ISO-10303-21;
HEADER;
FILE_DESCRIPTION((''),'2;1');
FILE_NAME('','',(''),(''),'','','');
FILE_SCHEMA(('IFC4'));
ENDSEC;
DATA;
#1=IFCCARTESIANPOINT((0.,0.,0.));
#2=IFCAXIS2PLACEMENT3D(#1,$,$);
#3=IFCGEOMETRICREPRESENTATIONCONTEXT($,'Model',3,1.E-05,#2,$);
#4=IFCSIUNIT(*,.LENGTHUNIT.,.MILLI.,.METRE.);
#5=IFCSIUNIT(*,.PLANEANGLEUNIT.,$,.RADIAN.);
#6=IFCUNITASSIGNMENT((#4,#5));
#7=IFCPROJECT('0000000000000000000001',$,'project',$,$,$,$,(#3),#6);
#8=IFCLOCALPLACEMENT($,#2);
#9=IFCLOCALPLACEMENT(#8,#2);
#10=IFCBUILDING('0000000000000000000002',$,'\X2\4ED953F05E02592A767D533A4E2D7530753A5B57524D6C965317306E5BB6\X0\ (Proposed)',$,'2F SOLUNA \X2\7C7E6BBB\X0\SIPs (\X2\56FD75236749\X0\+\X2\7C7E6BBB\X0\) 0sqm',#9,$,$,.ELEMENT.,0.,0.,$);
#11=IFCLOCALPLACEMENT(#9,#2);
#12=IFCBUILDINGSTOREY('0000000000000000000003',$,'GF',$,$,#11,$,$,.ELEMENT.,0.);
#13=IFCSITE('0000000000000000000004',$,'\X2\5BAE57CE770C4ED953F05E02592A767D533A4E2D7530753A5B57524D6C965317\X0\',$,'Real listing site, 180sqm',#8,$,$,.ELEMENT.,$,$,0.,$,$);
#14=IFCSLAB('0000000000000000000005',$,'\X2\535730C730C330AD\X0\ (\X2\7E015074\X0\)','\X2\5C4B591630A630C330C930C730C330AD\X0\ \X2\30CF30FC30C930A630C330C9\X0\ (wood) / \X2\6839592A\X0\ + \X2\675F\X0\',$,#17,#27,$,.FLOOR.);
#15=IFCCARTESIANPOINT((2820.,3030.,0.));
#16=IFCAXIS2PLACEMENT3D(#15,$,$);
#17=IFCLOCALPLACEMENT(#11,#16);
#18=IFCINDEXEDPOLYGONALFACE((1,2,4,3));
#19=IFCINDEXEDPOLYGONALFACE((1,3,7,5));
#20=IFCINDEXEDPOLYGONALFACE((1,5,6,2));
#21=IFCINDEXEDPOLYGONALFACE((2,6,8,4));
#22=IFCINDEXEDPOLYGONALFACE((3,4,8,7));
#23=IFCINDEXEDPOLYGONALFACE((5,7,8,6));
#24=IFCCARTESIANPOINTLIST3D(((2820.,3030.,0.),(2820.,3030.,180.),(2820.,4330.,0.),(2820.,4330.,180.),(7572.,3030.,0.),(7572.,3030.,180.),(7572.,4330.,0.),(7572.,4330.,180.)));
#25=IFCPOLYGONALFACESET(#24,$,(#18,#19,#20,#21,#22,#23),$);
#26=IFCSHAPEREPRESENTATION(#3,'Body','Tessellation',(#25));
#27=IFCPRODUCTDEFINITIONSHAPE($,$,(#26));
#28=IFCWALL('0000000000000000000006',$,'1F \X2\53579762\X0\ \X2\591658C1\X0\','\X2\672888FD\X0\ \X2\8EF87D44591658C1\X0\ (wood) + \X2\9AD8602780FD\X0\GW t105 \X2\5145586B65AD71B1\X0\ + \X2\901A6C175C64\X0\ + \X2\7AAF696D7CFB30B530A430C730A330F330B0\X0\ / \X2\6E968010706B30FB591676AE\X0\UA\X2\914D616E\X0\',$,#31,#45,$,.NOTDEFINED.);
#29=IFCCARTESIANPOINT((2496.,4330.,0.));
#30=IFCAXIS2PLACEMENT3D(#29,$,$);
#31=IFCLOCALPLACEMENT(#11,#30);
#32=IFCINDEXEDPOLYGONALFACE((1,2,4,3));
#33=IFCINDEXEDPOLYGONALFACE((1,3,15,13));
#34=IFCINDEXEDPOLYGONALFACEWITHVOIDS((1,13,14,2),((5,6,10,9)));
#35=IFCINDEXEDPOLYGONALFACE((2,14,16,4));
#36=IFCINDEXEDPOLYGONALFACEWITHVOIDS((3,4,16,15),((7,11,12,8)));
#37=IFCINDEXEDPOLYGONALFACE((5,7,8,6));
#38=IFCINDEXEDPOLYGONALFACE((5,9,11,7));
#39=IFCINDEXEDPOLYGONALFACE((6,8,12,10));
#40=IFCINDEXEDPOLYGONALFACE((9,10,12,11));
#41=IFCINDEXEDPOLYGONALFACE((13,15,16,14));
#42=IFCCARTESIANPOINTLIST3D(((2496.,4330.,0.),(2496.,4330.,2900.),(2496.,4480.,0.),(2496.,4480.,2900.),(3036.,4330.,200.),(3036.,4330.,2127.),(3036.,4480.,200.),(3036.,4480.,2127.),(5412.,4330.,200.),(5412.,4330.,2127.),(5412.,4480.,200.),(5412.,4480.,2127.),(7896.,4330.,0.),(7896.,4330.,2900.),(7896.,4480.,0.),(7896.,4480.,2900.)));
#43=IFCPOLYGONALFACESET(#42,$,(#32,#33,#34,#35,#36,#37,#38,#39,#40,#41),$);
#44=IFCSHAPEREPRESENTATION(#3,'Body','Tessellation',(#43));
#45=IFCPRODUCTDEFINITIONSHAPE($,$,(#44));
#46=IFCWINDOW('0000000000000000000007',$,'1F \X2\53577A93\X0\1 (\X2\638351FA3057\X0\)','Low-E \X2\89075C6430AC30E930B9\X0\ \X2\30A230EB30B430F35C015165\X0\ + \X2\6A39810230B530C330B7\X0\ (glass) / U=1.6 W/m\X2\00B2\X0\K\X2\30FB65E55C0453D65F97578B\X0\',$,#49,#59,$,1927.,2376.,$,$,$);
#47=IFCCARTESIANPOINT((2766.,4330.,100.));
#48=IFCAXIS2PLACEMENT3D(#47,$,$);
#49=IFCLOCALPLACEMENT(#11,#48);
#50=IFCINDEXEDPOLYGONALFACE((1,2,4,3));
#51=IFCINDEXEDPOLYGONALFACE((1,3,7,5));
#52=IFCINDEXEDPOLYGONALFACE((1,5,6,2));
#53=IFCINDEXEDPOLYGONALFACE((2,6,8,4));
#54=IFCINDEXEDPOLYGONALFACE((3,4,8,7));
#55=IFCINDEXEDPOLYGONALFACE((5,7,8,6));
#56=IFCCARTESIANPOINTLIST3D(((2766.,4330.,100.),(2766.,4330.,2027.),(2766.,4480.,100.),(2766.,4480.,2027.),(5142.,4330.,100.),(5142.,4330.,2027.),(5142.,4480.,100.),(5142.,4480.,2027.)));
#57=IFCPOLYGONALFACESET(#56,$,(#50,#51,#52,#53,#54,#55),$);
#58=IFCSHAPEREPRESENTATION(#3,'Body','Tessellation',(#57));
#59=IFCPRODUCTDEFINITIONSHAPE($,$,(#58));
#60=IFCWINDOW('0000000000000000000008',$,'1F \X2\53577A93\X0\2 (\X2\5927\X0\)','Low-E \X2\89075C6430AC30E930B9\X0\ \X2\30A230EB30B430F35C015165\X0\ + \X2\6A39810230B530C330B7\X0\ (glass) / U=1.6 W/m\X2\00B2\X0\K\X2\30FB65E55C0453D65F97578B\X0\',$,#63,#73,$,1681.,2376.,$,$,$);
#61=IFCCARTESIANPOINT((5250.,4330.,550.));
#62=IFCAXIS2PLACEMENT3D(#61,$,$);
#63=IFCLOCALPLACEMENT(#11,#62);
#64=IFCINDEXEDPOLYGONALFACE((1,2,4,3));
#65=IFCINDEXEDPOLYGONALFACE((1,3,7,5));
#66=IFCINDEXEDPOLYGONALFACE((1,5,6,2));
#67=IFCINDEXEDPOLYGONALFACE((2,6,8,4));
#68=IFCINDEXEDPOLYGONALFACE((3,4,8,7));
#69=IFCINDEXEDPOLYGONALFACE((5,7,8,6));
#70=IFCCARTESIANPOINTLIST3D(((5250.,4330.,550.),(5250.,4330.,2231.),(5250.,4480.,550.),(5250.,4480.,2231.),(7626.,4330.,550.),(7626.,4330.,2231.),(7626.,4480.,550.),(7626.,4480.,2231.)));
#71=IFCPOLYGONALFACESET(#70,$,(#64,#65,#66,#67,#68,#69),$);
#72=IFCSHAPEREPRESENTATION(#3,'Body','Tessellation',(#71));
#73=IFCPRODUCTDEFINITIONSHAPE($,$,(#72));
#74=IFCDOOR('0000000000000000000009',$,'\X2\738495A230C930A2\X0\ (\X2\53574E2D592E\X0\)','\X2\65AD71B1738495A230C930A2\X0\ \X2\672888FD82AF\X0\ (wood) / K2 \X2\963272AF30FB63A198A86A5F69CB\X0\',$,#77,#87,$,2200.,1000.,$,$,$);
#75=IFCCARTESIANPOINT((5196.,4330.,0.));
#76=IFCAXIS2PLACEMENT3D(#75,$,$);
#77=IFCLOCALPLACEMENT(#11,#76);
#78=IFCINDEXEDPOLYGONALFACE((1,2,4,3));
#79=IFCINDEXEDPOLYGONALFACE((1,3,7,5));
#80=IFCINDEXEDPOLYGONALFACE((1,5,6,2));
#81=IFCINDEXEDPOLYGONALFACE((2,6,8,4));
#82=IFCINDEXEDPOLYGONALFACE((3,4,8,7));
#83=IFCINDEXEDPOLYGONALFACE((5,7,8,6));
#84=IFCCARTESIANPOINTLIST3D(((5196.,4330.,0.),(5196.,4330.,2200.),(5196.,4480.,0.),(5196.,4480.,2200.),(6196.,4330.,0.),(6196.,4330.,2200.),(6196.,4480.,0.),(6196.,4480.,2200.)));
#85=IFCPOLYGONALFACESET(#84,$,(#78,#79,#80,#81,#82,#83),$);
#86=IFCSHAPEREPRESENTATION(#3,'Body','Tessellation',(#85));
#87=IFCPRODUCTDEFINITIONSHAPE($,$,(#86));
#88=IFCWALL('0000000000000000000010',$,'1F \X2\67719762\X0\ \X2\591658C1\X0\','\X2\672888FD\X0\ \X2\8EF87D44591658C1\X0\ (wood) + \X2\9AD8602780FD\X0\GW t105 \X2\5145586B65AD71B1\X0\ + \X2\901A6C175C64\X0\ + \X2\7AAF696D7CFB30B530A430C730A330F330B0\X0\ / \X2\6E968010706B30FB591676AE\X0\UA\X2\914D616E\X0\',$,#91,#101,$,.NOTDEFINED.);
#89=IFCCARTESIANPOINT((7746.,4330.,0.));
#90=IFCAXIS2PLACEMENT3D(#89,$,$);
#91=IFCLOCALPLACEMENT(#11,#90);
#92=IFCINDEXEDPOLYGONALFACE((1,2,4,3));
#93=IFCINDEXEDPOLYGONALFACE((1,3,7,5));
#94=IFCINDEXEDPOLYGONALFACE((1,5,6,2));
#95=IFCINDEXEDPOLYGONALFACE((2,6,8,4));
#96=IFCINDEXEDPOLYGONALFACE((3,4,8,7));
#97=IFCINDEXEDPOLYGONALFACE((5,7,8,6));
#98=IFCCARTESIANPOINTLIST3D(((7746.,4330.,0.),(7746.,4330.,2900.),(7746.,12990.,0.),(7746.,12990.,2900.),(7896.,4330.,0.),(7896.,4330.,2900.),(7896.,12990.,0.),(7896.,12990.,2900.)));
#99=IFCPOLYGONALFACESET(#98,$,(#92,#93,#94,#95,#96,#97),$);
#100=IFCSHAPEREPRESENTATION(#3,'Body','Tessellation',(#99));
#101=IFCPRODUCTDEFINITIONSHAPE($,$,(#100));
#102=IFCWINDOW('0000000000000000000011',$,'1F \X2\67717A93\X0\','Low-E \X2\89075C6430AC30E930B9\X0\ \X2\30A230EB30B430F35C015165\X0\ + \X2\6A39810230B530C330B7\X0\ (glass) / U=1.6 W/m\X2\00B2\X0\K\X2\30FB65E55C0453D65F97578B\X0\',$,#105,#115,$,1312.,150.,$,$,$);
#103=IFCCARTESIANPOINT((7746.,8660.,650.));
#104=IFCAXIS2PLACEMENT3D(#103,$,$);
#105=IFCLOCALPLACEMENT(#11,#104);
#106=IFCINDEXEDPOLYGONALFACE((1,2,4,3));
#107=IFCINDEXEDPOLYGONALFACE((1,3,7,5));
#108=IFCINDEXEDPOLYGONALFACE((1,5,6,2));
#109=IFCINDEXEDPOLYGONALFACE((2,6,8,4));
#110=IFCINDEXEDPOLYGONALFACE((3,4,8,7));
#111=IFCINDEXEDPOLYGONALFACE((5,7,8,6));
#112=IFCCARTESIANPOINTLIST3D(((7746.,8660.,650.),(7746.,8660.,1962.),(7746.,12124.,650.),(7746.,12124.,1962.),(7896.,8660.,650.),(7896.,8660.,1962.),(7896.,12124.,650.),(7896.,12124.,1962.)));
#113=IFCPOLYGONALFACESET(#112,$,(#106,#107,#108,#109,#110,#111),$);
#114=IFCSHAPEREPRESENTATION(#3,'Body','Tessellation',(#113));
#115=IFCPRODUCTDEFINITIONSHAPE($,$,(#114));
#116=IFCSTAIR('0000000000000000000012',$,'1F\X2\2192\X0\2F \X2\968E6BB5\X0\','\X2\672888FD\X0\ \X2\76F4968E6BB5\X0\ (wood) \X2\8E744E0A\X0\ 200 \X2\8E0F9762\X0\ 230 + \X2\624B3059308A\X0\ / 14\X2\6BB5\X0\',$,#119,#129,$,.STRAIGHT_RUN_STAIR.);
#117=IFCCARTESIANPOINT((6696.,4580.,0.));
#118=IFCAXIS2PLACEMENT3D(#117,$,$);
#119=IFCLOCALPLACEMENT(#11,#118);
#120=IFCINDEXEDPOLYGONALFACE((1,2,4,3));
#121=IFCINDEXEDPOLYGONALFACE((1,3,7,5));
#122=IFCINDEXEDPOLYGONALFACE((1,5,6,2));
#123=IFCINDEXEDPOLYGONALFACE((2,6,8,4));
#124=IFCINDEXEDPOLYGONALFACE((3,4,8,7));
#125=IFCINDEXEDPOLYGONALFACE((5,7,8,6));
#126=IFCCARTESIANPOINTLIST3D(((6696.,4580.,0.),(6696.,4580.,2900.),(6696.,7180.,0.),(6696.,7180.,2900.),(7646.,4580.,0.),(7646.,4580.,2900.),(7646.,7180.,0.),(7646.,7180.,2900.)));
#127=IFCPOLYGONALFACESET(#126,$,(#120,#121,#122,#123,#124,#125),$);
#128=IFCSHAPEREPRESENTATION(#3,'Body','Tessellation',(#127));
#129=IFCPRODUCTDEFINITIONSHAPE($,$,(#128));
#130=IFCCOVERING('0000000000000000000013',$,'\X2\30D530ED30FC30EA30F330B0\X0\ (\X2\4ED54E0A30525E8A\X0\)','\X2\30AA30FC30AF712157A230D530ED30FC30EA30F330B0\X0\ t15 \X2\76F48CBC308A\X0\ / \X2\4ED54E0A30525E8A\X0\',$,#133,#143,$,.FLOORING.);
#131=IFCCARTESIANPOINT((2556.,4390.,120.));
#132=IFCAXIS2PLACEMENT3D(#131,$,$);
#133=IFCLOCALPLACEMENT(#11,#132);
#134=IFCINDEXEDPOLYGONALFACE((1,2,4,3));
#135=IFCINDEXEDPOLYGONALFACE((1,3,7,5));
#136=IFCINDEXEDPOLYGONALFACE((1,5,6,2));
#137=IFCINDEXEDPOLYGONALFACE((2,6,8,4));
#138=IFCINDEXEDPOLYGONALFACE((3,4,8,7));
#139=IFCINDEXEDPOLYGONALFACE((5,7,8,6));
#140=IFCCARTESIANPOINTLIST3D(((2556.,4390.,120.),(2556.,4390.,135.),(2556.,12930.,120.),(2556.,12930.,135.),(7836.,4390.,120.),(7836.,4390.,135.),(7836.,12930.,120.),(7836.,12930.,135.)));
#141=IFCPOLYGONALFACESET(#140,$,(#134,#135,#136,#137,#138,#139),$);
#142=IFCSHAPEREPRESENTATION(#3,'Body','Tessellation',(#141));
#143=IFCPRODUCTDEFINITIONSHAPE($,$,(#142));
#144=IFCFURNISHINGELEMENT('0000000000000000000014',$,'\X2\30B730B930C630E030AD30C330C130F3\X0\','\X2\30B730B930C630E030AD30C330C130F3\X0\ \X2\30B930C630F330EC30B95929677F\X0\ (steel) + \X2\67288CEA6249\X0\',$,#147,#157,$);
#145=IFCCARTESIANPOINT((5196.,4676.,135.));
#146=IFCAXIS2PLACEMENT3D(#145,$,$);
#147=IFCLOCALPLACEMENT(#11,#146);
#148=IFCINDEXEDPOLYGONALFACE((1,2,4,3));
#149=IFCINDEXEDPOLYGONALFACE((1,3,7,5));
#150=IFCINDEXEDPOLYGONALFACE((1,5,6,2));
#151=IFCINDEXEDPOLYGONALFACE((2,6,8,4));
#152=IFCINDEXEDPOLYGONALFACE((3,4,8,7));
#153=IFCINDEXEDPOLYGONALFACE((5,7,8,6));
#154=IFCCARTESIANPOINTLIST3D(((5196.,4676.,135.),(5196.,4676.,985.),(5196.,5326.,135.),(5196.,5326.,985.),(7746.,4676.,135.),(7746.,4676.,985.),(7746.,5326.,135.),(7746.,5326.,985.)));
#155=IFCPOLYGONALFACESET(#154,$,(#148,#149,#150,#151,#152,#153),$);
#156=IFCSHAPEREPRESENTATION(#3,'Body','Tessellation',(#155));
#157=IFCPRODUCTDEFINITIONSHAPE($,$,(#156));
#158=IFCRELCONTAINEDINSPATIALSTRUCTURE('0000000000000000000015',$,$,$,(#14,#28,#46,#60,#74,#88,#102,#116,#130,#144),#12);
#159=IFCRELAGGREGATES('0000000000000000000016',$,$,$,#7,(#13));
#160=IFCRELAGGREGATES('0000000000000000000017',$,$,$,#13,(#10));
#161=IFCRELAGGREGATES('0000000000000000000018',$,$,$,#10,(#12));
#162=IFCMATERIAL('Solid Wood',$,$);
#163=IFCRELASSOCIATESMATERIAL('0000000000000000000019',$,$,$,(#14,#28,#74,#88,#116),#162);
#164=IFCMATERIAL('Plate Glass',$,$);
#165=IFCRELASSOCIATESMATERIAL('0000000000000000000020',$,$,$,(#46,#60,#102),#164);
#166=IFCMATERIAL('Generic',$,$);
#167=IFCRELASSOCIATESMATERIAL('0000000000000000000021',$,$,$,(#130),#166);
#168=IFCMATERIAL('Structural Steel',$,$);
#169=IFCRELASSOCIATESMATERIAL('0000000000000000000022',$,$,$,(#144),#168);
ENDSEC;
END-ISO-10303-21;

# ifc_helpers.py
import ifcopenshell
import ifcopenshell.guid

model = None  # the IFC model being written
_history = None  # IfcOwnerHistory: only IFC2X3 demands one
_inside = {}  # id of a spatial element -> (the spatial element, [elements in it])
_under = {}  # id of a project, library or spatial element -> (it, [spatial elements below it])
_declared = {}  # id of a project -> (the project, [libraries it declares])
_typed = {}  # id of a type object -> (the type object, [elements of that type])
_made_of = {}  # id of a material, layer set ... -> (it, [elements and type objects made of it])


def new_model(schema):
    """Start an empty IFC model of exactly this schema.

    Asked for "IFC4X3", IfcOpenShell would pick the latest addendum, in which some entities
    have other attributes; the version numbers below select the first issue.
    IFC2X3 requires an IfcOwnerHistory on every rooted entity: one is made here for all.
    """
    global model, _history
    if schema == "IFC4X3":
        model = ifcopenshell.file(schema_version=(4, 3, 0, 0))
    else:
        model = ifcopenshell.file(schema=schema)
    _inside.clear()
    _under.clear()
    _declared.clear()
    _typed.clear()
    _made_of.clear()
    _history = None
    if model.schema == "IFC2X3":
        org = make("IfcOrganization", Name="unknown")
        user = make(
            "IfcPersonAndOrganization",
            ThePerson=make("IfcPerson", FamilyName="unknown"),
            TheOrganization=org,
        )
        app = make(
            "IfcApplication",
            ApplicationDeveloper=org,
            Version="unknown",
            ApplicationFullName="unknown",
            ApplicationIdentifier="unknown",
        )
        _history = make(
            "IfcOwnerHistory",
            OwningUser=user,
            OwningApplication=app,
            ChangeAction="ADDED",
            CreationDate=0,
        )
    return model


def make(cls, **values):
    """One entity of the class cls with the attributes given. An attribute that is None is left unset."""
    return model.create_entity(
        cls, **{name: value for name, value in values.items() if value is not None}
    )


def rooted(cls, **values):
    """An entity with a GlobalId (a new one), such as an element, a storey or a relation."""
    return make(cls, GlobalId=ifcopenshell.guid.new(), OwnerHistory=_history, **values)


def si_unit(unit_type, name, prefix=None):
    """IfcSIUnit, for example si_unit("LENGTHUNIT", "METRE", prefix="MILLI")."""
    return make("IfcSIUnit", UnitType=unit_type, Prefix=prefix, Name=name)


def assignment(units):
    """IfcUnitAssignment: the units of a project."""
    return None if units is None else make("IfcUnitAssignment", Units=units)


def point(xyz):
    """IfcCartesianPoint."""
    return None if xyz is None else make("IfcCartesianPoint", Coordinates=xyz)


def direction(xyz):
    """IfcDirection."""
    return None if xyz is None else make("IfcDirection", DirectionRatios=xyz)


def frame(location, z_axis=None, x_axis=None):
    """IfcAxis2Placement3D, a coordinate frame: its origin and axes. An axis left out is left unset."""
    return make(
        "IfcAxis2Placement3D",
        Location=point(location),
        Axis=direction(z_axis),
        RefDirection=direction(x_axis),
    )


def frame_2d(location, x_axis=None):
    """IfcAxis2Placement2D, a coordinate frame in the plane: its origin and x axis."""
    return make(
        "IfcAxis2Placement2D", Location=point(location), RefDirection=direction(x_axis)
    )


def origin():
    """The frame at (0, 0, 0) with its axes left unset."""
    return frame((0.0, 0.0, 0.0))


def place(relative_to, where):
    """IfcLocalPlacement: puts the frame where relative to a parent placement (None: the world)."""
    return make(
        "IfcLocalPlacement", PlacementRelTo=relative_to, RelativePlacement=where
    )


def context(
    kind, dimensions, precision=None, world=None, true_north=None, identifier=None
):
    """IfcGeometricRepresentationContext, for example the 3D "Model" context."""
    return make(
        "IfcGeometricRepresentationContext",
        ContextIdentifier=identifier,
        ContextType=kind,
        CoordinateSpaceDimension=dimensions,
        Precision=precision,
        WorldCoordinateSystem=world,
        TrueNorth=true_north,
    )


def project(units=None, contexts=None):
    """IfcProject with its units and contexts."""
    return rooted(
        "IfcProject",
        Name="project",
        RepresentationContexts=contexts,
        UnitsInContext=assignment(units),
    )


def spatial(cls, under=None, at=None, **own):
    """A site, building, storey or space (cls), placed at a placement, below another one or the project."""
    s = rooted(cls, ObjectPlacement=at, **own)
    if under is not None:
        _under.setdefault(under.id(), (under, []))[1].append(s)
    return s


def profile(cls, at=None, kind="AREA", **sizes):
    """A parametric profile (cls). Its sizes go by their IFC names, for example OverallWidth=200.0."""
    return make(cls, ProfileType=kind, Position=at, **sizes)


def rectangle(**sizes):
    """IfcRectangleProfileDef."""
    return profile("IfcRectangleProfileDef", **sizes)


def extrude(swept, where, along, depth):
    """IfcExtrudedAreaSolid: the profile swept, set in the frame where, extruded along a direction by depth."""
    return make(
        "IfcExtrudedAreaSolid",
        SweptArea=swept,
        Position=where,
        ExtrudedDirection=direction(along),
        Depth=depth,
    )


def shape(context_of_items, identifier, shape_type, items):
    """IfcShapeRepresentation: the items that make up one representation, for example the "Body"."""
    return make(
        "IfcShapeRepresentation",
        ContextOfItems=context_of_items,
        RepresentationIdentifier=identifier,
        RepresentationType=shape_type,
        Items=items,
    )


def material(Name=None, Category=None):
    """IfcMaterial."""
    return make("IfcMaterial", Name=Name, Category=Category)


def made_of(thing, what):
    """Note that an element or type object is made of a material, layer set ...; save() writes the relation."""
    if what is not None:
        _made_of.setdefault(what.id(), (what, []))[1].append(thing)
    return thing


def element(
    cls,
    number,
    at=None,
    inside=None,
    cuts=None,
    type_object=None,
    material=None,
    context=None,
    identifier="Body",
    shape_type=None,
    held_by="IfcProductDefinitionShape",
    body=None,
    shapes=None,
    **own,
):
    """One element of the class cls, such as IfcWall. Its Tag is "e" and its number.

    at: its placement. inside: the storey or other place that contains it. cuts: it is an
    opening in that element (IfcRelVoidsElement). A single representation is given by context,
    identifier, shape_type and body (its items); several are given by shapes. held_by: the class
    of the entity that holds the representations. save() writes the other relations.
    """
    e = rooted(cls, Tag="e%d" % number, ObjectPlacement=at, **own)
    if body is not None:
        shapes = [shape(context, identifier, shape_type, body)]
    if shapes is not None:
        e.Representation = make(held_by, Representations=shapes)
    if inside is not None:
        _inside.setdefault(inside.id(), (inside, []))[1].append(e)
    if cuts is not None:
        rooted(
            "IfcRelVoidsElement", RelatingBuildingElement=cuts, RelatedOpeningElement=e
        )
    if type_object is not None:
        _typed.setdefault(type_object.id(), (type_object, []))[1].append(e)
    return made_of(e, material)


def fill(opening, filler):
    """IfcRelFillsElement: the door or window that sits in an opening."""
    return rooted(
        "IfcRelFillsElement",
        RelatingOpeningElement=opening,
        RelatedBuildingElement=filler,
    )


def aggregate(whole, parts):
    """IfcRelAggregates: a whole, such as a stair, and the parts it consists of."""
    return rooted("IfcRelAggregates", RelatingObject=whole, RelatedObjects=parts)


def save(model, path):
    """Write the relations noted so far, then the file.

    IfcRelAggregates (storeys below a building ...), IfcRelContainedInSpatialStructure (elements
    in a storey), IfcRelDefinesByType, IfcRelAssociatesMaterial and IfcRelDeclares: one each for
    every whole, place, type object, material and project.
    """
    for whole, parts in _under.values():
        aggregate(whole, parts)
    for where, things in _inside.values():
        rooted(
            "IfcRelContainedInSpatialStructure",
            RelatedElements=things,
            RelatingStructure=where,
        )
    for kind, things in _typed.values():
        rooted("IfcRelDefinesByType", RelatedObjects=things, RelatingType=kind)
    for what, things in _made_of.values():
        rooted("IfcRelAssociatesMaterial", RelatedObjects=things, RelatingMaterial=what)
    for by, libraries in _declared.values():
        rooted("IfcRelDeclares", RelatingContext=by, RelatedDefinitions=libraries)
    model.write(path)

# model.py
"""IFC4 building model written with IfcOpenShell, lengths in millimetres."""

from ifc_helpers import new_model, si_unit, frame, frame_2d, origin, place, context, project, spatial, rectangle, extrude, material, element, fill, save


model = new_model("IFC4")

# Units and contexts
model_context = context("Model", 3, precision=1e-05, world=origin())
ifc_project = project(units=[si_unit("LENGTHUNIT", "METRE", prefix="MILLI"), si_unit("PLANEANGLEUNIT", "RADIAN")], contexts=[model_context])

# Site, building, storey
site_placement = place(None, origin())
site = spatial("IfcSite", under=ifc_project, at=site_placement, Name="宮城県仙台市太白区中田町字前沖北", ObjectType="Real listing site, 180sqm", CompositionType="ELEMENT", RefElevation=0.0)
building_placement = place(site_placement, origin())
building = spatial("IfcBuilding", under=site, at=building_placement, Name="仙台市太白区中田町字前沖北の家 (Proposed)", ObjectType="2F SOLUNA 籾殻SIPs (国産杉+籾殻) 0sqm", CompositionType="ELEMENT", ElevationOfRefHeight=0.0, ElevationOfTerrain=0.0)
storey_placement = place(building_placement, origin())
storey = spatial("IfcBuildingStorey", under=building, at=storey_placement, Name="GF", CompositionType="ELEMENT", Elevation=0.0)

# Slab
ifc_material_1 = material(Name="Solid Wood")
slab_1_placement = place(storey_placement, frame((2820.0, 3030.0, 0.0)))
element("IfcSlab", 1, at=slab_1_placement, inside=storey, material=ifc_material_1, Name="南デッキ (縁側)", Description="屋外ウッドデッキ ハードウッド (wood) / 根太 + 束", PredefinedType="FLOOR", context=model_context, shape_type="SweptSolid", body=[
    extrude(rectangle(XDim=4752.0, YDim=1300.0, at=frame_2d((2376.0, 650.0))), frame((2820.0, 3030.0, 0.0)), (0.0, 0.0, 1.0), 180.0),
])

# Wall, openings, windows, door
wall_1_placement = place(storey_placement, frame((2496.0, 4330.0, 0.0)))
wall_1 = element("IfcWall", 2, at=wall_1_placement, inside=storey, material=ifc_material_1, Name="1F 南面 外壁", Description="木製 軸組外壁 (wood) + 高性能GW t105 充填断熱 + 通気層 + 窯業系サイディング / 準耐火・外皮UA配慮", PredefinedType="NOTDEFINED", context=model_context, shape_type="SweptSolid", body=[
    extrude(rectangle(XDim=5400.0, YDim=150.0, at=frame_2d((2700.0, 75.0))), frame((2496.0, 4330.0, 0.0)), (0.0, 0.0, 1.0), 2900.0),
])
opening_1_placement = place(storey_placement, frame((2766.0, 4330.0, 100.0)))
opening_1 = element("IfcOpeningElement", 3, at=opening_1_placement, cuts=wall_1, PredefinedType="NOTDEFINED", context=model_context, shape_type="SweptSolid", body=[
    extrude(rectangle(XDim=2376.0, YDim=150.0, at=frame_2d((1188.0, 75.0))), frame((2766.0, 4330.0, 100.0)), (0.0, 0.0, 1.0), 1927.0),
])
opening_2_placement = place(storey_placement, frame((5250.0, 4330.0, 550.0)))
opening_2 = element("IfcOpeningElement", 4, at=opening_2_placement, cuts=wall_1, PredefinedType="NOTDEFINED", context=model_context, shape_type="SweptSolid", body=[
    extrude(rectangle(XDim=2376.0, YDim=150.0, at=frame_2d((1188.0, 75.0))), frame((5250.0, 4330.0, 550.0)), (0.0, 0.0, 1.0), 1681.0),
])
opening_3_placement = place(storey_placement, frame((5196.0, 4330.0, 0.0)))
opening_3 = element("IfcOpeningElement", 5, at=opening_3_placement, cuts=wall_1, PredefinedType="NOTDEFINED", context=model_context, shape_type="SweptSolid", body=[
    extrude(rectangle(XDim=1000.0, YDim=150.0, at=frame_2d((500.0, 75.0))), frame((5196.0, 4330.0, 0.0)), (0.0, 0.0, 1.0), 2200.0),
])
ifc_material_2 = material(Name="Plate Glass")
window_1_placement = place(storey_placement, frame((2766.0, 4330.0, 100.0)))
window_1 = element("IfcWindow", 6, at=window_1_placement, inside=storey, material=ifc_material_2, Name="1F 南窓1 (掃出し)", Description="Low-E 複層ガラス アルゴン封入 + 樹脂サッシ (glass) / U=1.6 W/m²K・日射取得型", OverallHeight=1927.0, OverallWidth=2376.0, context=model_context, shape_type="SweptSolid", body=[
    extrude(rectangle(XDim=2376.0, YDim=150.0, at=frame_2d((1188.0, 75.0))), frame((2766.0, 4330.0, 100.0)), (0.0, 0.0, 1.0), 1927.0),
])
fill(opening_1, window_1)
window_2_placement = place(storey_placement, frame((5250.0, 4330.0, 550.0)))
window_2 = element("IfcWindow", 7, at=window_2_placement, inside=storey, material=ifc_material_2, Name="1F 南窓2 (大)", Description="Low-E 複層ガラス アルゴン封入 + 樹脂サッシ (glass) / U=1.6 W/m²K・日射取得型", OverallHeight=1681.0, OverallWidth=2376.0, context=model_context, shape_type="SweptSolid", body=[
    extrude(rectangle(XDim=2376.0, YDim=150.0, at=frame_2d((1188.0, 75.0))), frame((5250.0, 4330.0, 550.0)), (0.0, 0.0, 1.0), 1681.0),
])
fill(opening_2, window_2)
door_placement = place(storey_placement, frame((5196.0, 4330.0, 0.0)))
door = element("IfcDoor", 8, at=door_placement, inside=storey, material=ifc_material_1, Name="玄関ドア (南中央)", Description="断熱玄関ドア 木製芯 (wood) / K2 防犯・採風機構", OverallHeight=2200.0, OverallWidth=1000.0, context=model_context, shape_type="SweptSolid", body=[
    extrude(rectangle(XDim=1000.0, YDim=150.0, at=frame_2d((500.0, 75.0))), frame((5196.0, 4330.0, 0.0)), (0.0, 0.0, 1.0), 2200.0),
])
fill(opening_3, door)

# Wall, opening, window
wall_2_placement = place(storey_placement, frame((7746.0, 4330.0, 0.0)))
wall_2 = element("IfcWall", 9, at=wall_2_placement, inside=storey, material=ifc_material_1, Name="1F 東面 外壁", Description="木製 軸組外壁 (wood) + 高性能GW t105 充填断熱 + 通気層 + 窯業系サイディング / 準耐火・外皮UA配慮", PredefinedType="NOTDEFINED", context=model_context, shape_type="SweptSolid", body=[
    extrude(rectangle(XDim=150.0, YDim=8660.0, at=frame_2d((75.0, 4330.0))), frame((7746.0, 4330.0, 0.0)), (0.0, 0.0, 1.0), 2900.0),
])
opening_4_placement = place(storey_placement, frame((7746.0, 8660.0, 650.0)))
opening_4 = element("IfcOpeningElement", 10, at=opening_4_placement, cuts=wall_2, PredefinedType="NOTDEFINED", context=model_context, shape_type="SweptSolid", body=[
    extrude(rectangle(XDim=150.0, YDim=3464.0, at=frame_2d((75.0, 1732.0))), frame((7746.0, 8660.0, 650.0)), (0.0, 0.0, 1.0), 1312.0),
])
window_3_placement = place(storey_placement, frame((7746.0, 8660.0, 650.0)))
window_3 = element("IfcWindow", 11, at=window_3_placement, inside=storey, material=ifc_material_2, Name="1F 東窓", Description="Low-E 複層ガラス アルゴン封入 + 樹脂サッシ (glass) / U=1.6 W/m²K・日射取得型", OverallHeight=1312.0, OverallWidth=150.0, context=model_context, shape_type="SweptSolid", body=[
    extrude(rectangle(XDim=150.0, YDim=3464.0, at=frame_2d((75.0, 1732.0))), frame((7746.0, 8660.0, 650.0)), (0.0, 0.0, 1.0), 1312.0),
])
fill(opening_4, window_3)

# Stair
stair_placement = place(storey_placement, frame((6696.0, 4580.0, 0.0)))
element("IfcStair", 12, at=stair_placement, inside=storey, material=ifc_material_1, Name="1F→2F 階段", Description="木製 直階段 (wood) 蹴上 200 踏面 230 + 手すり / 14段", PredefinedType="STRAIGHT_RUN_STAIR", context=model_context, shape_type="SweptSolid", body=[
    extrude(rectangle(XDim=950.0, YDim=2600.0, at=frame_2d((475.0, 1300.0))), frame((6696.0, 4580.0, 0.0)), (0.0, 0.0, 1.0), 2900.0),
])

# Covering
ifc_material_3 = material(Name="Generic")
covering_placement = place(storey_placement, frame((2556.0, 4390.0, 120.0)))
element("IfcCovering", 13, at=covering_placement, inside=storey, material=ifc_material_3, Name="フローリング (仕上げ床)", Description="オーク無垢フローリング t15 直貼り / 仕上げ床", PredefinedType="FLOORING", context=model_context, shape_type="SweptSolid", body=[
    extrude(rectangle(XDim=5280.0, YDim=8540.0, at=frame_2d((2640.0, 4270.0))), frame((2556.0, 4390.0, 120.0)), (0.0, 0.0, 1.0), 15.0),
])

# Furnishing element
ifc_material_4 = material(Name="Structural Steel")
furnishing_placement = place(storey_placement, frame((5196.0, 4676.0, 135.0)))
element("IfcFurnishingElement", 14, at=furnishing_placement, inside=storey, material=ifc_material_4, Name="システムキッチン", Description="システムキッチン ステンレス天板 (steel) + 木質扉", context=model_context, shape_type="SweptSolid", body=[
    extrude(rectangle(XDim=2550.0, YDim=650.0, at=frame_2d((1275.0, 325.0))), frame((5196.0, 4676.0, 135.0)), (0.0, 0.0, 1.0), 850.0),
])

save(model, "model.ifc")
